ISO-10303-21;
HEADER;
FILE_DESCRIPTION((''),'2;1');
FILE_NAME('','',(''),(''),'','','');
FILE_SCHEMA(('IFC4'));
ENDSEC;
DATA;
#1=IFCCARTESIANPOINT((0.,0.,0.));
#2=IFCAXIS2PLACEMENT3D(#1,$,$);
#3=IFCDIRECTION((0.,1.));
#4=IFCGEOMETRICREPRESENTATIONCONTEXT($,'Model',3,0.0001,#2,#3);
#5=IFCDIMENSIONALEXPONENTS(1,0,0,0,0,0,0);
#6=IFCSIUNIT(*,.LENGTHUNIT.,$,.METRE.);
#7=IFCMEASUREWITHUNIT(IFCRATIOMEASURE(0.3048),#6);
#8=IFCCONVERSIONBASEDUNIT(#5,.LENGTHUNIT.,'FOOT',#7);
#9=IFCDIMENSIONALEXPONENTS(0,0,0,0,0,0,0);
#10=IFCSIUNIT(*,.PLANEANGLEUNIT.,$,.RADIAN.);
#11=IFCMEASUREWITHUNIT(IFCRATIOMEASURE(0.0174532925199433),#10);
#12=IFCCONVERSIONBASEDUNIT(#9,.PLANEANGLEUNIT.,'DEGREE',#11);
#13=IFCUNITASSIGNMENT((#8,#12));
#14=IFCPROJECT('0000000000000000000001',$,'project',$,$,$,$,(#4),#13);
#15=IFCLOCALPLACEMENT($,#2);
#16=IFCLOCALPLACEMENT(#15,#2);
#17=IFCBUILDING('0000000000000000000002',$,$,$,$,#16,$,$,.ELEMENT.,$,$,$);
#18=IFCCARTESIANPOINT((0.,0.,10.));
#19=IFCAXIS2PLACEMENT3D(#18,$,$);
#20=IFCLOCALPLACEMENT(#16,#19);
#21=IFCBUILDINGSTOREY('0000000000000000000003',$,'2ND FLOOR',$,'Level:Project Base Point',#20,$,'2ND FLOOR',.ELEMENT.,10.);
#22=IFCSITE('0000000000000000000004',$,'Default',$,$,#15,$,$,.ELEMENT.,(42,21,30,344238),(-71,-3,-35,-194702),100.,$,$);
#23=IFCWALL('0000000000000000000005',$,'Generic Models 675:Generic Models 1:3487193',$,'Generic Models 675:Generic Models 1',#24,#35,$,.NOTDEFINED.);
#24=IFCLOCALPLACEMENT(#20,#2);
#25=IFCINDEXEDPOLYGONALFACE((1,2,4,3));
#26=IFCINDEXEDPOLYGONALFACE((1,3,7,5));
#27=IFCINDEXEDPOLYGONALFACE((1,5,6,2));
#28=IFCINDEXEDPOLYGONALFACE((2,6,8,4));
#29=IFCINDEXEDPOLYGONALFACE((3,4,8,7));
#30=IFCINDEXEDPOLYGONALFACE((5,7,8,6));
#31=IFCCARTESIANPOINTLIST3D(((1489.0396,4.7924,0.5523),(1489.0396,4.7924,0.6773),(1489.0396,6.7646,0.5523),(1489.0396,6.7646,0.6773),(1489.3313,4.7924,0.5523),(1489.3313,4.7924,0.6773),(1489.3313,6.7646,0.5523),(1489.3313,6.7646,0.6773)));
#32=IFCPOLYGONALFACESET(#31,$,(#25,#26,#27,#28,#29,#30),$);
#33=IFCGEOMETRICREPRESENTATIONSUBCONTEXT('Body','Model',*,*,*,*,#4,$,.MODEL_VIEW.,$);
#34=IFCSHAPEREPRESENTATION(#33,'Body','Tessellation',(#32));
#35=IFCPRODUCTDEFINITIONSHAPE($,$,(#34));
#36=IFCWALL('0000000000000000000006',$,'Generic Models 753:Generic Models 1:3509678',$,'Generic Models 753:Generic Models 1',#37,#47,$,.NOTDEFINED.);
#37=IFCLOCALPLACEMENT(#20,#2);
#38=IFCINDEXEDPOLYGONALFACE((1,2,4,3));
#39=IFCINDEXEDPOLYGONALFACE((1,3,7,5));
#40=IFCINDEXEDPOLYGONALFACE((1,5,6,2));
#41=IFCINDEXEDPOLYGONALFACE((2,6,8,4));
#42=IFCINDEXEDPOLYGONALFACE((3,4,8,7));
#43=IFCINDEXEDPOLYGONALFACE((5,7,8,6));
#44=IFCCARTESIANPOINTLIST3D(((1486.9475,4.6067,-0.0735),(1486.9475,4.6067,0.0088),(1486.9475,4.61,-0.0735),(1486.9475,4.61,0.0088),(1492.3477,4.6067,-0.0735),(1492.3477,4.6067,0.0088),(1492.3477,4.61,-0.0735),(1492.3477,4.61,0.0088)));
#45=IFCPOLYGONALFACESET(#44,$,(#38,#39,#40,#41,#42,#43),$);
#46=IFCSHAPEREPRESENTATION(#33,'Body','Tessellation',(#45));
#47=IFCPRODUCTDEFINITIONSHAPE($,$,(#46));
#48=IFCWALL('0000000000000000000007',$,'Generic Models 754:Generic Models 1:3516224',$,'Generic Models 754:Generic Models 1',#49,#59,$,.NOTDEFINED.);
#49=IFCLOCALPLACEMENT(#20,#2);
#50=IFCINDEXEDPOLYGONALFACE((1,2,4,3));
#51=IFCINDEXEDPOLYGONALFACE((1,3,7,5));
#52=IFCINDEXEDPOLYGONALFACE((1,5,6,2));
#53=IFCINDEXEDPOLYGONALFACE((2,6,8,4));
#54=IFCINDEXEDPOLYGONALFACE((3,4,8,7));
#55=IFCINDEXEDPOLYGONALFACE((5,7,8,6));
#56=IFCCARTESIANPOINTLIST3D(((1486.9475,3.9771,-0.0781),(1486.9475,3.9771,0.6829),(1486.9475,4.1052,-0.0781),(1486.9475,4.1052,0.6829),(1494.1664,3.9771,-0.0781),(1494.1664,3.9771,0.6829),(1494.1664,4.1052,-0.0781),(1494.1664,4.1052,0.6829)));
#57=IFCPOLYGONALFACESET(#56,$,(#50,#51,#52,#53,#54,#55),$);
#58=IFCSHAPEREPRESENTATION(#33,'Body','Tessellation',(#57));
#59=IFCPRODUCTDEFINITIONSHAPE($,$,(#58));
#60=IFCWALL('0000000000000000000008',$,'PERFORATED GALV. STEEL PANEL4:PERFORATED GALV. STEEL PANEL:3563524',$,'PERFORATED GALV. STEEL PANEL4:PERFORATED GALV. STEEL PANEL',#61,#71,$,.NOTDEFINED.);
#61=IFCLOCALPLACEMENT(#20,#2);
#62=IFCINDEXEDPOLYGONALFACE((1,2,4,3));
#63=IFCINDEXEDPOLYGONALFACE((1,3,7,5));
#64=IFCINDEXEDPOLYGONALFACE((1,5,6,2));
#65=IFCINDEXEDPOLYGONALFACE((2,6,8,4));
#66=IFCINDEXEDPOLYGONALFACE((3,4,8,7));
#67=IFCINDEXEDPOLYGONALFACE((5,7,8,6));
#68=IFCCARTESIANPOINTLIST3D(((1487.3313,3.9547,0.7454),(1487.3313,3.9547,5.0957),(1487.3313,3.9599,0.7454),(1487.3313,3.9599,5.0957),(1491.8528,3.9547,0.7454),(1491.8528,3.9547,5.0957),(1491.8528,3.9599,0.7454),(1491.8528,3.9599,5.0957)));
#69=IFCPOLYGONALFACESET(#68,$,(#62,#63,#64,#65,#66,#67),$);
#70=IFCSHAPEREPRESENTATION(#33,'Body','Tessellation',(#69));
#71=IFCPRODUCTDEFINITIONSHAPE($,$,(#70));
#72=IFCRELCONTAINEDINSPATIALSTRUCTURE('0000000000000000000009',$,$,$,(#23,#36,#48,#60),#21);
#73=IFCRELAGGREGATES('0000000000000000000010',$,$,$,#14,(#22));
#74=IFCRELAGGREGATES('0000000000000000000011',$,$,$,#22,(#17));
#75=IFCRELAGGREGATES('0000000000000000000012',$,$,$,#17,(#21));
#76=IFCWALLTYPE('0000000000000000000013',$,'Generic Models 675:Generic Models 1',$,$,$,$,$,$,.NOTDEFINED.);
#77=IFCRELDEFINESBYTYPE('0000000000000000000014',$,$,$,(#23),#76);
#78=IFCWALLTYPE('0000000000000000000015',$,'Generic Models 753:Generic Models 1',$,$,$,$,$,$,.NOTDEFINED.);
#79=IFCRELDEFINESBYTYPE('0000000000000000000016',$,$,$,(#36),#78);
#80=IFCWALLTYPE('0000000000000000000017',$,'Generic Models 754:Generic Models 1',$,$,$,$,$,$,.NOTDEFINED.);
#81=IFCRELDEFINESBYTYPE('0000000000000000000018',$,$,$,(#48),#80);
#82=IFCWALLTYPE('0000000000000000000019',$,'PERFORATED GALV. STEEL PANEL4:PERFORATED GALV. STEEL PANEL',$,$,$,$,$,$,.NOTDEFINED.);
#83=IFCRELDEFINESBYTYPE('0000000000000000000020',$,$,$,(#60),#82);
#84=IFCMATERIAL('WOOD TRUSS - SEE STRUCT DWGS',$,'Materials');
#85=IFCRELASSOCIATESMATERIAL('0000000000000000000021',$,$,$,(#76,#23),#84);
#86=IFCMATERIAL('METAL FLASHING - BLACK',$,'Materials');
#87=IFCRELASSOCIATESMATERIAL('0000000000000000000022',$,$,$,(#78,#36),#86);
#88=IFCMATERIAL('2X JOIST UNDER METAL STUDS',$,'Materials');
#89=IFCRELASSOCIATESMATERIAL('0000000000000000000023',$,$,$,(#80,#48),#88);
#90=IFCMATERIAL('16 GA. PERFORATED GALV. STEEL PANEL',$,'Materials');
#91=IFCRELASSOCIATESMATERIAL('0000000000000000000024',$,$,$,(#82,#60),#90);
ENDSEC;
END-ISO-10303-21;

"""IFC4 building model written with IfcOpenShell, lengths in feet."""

from ifc_helpers import new_model, entity, si_unit, converted_unit, direction, frame, frame_2d, origin, place, context, subcontext, project, spatial, rectangle, extrude, material, type_object, element, save


model = new_model("IFC4")

# Units and contexts
model_context = context("Model", 3, precision=0.0001, world=origin(), true_north=direction((0.0, 1.0)))
body_context = subcontext(model_context, "Body", "Model", "MODEL_VIEW")
ifc_project = project(units=[converted_unit("LENGTHUNIT", "FOOT", entity("IfcRatioMeasure", 0.3048), si_unit("LENGTHUNIT", "METRE"), dimensions=[1, 0, 0, 0, 0, 0, 0]), converted_unit("PLANEANGLEUNIT", "DEGREE", entity("IfcRatioMeasure", 0.0174532925199433), si_unit("PLANEANGLEUNIT", "RADIAN"), dimensions=[0, 0, 0, 0, 0, 0, 0])], contexts=[model_context])

# Site, building, storey
site_placement = place(None, origin())
site = spatial("IfcSite", under=ifc_project, at=site_placement, Name="Default", CompositionType="ELEMENT", RefLatitude=(42, 21, 30, 344238), RefLongitude=(-71, -3, -35, -194702), RefElevation=100.0)
building_placement = place(site_placement, origin())
building = spatial("IfcBuilding", under=site, at=building_placement, CompositionType="ELEMENT")
storey_placement = place(building_placement, frame((0.0, 0.0, 10.0)))
storey = spatial("IfcBuildingStorey", under=building, at=storey_placement, Name="2ND FLOOR", ObjectType="Level:Project Base Point", LongName="2ND FLOOR", CompositionType="ELEMENT", Elevation=10.0)

# Walls
ifc_material_1 = material(Name="WOOD TRUSS - SEE STRUCT DWGS", Category="Materials")
wall_type_1 = type_object("IfcWallType", Name="Generic Models 675:Generic Models 1", PredefinedType="NOTDEFINED", material=ifc_material_1)
wall_1_placement = place(storey_placement, frame((1489.0396, 4.7924, 0.5523), z_axis=(0.0, 0.0, 1.0), x_axis=(0.0, 1.0, 0.0)))
element("IfcWall", 1, at=wall_1_placement, inside=storey, type_object=wall_type_1, material=ifc_material_1, Name="Generic Models 675:Generic Models 1:3487193", ObjectType="Generic Models 675:Generic Models 1", PredefinedType="NOTDEFINED", context=body_context, shape_type="SweptSolid", body=[
    extrude(rectangle(XDim=1.9723, YDim=0.2917, at=frame_2d((0.0, 0.0), x_axis=(1.0, 0.0))), frame((0.9861, -0.1458, 0.0)), (0.0, 0.0, 1.0), 0.125),
])
ifc_material_2 = material(Name="METAL FLASHING - BLACK", Category="Materials")
wall_type_2 = type_object("IfcWallType", Name="Generic Models 753:Generic Models 1", PredefinedType="NOTDEFINED", material=ifc_material_2)
wall_2_placement = place(storey_placement, frame((1486.9475, 4.6067, -0.0735)))
element("IfcWall", 2, at=wall_2_placement, inside=storey, type_object=wall_type_2, material=ifc_material_2, Name="Generic Models 753:Generic Models 1:3509678", ObjectType="Generic Models 753:Generic Models 1", PredefinedType="NOTDEFINED", context=body_context, shape_type="SweptSolid", body=[
    extrude(rectangle(XDim=5.4003, YDim=0.0033, at=frame_2d((0.0, 0.0), x_axis=(1.0, 0.0))), frame((2.7001, 0.0016, 0.0)), (0.0, 0.0, 1.0), 0.0823),
])
ifc_material_3 = material(Name="2X JOIST UNDER METAL STUDS", Category="Materials")
wall_type_3 = type_object("IfcWallType", Name="Generic Models 754:Generic Models 1", PredefinedType="NOTDEFINED", material=ifc_material_3)
wall_3_placement = place(storey_placement, frame((1486.9475, 3.9771, -0.0781)))
element("IfcWall", 3, at=wall_3_placement, inside=storey, type_object=wall_type_3, material=ifc_material_3, Name="Generic Models 754:Generic Models 1:3516224", ObjectType="Generic Models 754:Generic Models 1", PredefinedType="NOTDEFINED", context=body_context, shape_type="SweptSolid", body=[
    extrude(rectangle(XDim=0.1282, YDim=7.219, at=frame_2d((0.0, 0.0), x_axis=(1.0, 0.0))), frame((3.6095, 0.0641, 0.0), z_axis=(0.0, 0.0, 1.0), x_axis=(0.0, 1.0, 0.0)), (0.0, 0.0, 1.0), 0.761),
])
ifc_material_4 = material(Name="16 GA. PERFORATED GALV. STEEL PANEL", Category="Materials")
wall_type_4 = type_object("IfcWallType", Name="PERFORATED GALV. STEEL PANEL4:PERFORATED GALV. STEEL PANEL", PredefinedType="NOTDEFINED", material=ifc_material_4)
wall_4_placement = place(storey_placement, frame((1487.3313, 3.9547, 0.7454)))
element("IfcWall", 4, at=wall_4_placement, inside=storey, type_object=wall_type_4, material=ifc_material_4, Name="PERFORATED GALV. STEEL PANEL4:PERFORATED GALV. STEEL PANEL:3563524", ObjectType="PERFORATED GALV. STEEL PANEL4:PERFORATED GALV. STEEL PANEL", PredefinedType="NOTDEFINED", context=body_context, shape_type="SweptSolid", body=[
    extrude(rectangle(XDim=4.5215, YDim=0.0053, at=frame_2d((0.0, 0.0), x_axis=(1.0, 0.0))), frame((2.2608, 0.0026, 0.0), z_axis=(0.0, 0.0, 1.0), x_axis=(-1.0, 0.0, 0.0)), (0.0, 0.0, 1.0), 4.3503),
])

save(model, "model.ifc")
